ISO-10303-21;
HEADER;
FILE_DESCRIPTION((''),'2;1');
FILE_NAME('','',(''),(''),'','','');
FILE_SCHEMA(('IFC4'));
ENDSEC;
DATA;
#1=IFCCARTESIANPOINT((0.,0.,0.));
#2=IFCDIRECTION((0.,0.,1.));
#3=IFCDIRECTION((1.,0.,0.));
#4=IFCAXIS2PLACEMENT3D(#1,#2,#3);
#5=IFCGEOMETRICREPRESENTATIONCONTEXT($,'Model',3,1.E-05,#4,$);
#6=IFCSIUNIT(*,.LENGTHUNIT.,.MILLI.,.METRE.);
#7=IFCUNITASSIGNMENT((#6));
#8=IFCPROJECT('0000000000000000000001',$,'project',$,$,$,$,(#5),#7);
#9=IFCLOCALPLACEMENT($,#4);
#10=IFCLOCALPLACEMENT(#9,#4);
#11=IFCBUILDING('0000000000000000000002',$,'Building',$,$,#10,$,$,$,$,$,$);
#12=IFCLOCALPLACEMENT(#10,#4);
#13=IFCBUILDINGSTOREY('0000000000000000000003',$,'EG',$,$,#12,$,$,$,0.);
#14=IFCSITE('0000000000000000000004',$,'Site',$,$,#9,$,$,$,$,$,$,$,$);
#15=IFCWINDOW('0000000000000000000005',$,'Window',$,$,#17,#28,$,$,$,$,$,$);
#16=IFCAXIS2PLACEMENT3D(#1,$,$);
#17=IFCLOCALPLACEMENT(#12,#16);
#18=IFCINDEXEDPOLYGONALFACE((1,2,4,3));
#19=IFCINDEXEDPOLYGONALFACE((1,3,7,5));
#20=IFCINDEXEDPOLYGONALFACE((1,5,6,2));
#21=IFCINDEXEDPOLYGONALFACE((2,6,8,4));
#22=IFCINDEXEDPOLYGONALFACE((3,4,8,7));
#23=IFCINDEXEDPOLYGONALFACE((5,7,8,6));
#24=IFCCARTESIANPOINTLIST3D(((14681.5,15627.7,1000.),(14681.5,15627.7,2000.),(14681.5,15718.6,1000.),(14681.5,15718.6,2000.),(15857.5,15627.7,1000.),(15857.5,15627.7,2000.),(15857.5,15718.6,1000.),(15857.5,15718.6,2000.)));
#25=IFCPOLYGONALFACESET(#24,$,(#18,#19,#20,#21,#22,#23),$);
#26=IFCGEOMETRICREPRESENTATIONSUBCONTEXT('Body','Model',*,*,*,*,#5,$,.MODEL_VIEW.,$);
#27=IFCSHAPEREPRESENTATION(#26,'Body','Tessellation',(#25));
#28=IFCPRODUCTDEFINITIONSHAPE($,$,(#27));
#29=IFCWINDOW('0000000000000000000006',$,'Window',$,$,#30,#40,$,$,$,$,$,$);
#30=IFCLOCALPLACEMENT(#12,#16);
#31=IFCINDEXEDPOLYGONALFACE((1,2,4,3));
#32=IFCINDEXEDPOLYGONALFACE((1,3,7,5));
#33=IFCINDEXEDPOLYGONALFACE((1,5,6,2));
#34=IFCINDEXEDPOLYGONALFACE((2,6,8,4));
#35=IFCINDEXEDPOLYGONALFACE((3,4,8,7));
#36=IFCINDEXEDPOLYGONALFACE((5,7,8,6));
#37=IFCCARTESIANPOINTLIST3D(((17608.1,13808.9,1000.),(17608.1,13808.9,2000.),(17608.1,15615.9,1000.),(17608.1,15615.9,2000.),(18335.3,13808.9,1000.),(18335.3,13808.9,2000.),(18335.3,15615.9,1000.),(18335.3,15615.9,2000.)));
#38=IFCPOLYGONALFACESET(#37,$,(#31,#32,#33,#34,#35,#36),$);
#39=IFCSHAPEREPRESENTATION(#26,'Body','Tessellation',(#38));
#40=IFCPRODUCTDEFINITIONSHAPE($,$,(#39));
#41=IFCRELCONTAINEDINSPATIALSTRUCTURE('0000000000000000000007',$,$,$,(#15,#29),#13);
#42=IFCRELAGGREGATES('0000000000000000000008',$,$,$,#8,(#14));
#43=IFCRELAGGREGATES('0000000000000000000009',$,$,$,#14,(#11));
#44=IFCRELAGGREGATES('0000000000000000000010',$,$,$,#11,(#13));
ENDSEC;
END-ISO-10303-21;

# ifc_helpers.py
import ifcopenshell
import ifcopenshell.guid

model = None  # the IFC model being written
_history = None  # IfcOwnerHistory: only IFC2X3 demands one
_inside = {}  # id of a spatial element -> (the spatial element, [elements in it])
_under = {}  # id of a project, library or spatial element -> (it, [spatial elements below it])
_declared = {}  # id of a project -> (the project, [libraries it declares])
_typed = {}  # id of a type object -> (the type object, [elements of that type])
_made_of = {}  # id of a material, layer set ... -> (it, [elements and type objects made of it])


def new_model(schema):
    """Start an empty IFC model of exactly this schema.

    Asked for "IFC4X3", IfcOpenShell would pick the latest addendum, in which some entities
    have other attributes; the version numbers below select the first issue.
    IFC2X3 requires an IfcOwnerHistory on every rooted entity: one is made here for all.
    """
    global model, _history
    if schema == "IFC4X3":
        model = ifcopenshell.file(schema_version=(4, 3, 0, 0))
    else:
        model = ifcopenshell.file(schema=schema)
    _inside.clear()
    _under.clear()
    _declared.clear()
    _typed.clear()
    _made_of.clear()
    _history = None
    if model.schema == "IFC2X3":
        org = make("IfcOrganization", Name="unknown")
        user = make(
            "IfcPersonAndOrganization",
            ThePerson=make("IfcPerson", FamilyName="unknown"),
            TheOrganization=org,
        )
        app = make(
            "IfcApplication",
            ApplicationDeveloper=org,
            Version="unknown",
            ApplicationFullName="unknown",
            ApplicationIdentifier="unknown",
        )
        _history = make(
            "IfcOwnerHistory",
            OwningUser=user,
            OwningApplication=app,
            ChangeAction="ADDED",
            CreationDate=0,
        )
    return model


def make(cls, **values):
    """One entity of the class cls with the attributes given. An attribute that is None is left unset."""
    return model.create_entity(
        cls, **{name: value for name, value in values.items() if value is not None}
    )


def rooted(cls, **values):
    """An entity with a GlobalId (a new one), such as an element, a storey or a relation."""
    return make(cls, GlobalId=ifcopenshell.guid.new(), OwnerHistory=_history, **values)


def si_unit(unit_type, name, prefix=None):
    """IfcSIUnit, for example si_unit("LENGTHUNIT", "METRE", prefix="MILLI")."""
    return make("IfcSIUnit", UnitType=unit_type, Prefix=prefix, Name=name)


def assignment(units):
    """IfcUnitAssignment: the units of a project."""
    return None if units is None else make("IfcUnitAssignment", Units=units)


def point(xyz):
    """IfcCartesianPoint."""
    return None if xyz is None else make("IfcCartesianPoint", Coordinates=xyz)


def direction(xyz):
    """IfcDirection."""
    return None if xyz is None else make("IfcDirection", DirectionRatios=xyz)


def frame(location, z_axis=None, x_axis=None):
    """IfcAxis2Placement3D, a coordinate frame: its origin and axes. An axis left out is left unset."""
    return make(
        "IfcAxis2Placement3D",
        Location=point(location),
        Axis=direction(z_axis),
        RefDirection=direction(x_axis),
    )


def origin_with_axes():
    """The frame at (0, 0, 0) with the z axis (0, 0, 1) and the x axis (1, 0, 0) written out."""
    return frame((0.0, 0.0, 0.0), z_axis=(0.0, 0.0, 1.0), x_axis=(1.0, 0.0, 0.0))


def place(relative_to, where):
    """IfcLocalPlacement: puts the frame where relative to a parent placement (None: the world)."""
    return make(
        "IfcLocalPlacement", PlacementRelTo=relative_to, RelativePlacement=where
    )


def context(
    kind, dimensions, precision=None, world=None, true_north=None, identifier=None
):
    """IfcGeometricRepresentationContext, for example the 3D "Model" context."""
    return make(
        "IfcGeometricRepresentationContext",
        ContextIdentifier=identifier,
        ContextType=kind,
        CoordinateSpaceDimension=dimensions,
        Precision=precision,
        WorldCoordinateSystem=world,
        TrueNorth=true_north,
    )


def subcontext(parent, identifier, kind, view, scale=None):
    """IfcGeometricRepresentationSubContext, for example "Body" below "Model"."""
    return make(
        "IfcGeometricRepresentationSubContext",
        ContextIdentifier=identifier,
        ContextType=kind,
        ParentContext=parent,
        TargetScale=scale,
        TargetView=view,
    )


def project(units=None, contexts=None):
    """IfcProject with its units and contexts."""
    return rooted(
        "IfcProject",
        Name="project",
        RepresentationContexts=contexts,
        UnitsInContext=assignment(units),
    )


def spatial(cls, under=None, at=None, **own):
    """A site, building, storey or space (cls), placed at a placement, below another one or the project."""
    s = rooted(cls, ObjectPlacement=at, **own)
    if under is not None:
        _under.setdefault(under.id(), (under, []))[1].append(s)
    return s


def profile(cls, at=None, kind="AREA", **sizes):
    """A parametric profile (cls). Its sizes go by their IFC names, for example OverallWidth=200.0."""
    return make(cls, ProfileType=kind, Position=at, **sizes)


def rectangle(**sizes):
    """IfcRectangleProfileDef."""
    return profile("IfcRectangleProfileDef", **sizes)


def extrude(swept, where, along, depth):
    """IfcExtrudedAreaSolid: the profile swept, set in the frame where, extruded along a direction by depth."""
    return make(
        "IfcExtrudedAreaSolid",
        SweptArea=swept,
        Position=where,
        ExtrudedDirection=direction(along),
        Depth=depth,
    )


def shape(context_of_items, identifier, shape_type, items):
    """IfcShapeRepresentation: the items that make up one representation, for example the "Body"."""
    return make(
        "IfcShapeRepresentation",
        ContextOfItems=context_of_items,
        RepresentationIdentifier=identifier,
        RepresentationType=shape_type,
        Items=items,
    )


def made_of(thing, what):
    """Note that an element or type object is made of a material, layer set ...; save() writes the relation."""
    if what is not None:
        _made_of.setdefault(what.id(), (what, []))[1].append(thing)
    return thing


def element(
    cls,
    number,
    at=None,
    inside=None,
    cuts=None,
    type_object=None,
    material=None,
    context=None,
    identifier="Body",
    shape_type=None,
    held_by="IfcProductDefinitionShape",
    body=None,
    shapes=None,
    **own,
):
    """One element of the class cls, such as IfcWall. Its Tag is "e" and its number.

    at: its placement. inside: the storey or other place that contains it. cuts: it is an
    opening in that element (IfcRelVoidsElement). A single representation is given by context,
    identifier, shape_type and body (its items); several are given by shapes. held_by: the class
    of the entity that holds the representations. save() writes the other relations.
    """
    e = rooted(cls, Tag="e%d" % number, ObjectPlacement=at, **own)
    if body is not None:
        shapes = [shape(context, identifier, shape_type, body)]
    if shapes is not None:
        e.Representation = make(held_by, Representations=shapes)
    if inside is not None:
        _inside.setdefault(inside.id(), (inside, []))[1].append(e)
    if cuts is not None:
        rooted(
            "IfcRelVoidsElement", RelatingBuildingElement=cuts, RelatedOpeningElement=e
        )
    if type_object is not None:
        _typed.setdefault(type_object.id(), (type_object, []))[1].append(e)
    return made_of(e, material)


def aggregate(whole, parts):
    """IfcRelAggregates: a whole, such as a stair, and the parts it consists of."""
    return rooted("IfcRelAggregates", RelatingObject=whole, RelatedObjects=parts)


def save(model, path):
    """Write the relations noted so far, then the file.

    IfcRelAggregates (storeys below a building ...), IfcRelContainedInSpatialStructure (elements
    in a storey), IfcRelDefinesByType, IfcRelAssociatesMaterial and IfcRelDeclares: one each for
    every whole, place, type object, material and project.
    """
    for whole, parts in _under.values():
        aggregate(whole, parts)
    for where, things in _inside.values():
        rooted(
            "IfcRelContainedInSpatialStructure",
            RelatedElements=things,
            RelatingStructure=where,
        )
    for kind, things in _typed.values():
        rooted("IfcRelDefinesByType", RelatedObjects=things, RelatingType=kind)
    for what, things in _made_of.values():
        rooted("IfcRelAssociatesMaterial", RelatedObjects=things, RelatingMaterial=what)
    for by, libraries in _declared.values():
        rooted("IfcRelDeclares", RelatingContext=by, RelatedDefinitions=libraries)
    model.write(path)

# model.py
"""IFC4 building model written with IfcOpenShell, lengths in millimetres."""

from ifc_helpers import new_model, si_unit, frame, origin_with_axes, place, context, subcontext, project, spatial, rectangle, extrude, element, save


model = new_model("IFC4")

# Units and contexts
model_context = context("Model", 3, precision=1e-05, world=origin_with_axes())
body_context = subcontext(model_context, "Body", "Model", "MODEL_VIEW")
ifc_project = project(units=[si_unit("LENGTHUNIT", "METRE", prefix="MILLI")], contexts=[model_context])

# Site, building, storey
site_placement = place(None, origin_with_axes())
site = spatial("IfcSite", under=ifc_project, at=site_placement, Name="Site")
building_placement = place(site_placement, origin_with_axes())
building = spatial("IfcBuilding", under=site, at=building_placement, Name="Building")
storey_placement = place(building_placement, origin_with_axes())
storey = spatial("IfcBuildingStorey", under=building, at=storey_placement, Name="EG", Elevation=0.0)

# Windows
window_1_placement = place(storey_placement, origin_with_axes())
element("IfcWindow", 1, at=window_1_placement, inside=storey, Name="Window", context=body_context, shape_type="SweptSolid", body=[
    extrude(rectangle(XDim=1176.0, YDim=90.9), frame((15269.5, 15673.2, 1000.0), z_axis=(0.0, 0.0, 1.0), x_axis=(1.0, 0.0, 0.0)), (0.0, 0.0, 1.0), 1000.0),
])
window_2_placement = place(storey_placement, origin_with_axes())
element("IfcWindow", 2, at=window_2_placement, inside=storey, Name="Window", context=body_context, shape_type="SweptSolid", body=[
    extrude(rectangle(XDim=1807.0, YDim=727.2), frame((17971.7, 14712.4, 1000.0), z_axis=(0.0, 0.0, 1.0), x_axis=(0.0, 1.0, 0.0)), (0.0, 0.0, 1.0), 1000.0),
])

save(model, "model.ifc")
